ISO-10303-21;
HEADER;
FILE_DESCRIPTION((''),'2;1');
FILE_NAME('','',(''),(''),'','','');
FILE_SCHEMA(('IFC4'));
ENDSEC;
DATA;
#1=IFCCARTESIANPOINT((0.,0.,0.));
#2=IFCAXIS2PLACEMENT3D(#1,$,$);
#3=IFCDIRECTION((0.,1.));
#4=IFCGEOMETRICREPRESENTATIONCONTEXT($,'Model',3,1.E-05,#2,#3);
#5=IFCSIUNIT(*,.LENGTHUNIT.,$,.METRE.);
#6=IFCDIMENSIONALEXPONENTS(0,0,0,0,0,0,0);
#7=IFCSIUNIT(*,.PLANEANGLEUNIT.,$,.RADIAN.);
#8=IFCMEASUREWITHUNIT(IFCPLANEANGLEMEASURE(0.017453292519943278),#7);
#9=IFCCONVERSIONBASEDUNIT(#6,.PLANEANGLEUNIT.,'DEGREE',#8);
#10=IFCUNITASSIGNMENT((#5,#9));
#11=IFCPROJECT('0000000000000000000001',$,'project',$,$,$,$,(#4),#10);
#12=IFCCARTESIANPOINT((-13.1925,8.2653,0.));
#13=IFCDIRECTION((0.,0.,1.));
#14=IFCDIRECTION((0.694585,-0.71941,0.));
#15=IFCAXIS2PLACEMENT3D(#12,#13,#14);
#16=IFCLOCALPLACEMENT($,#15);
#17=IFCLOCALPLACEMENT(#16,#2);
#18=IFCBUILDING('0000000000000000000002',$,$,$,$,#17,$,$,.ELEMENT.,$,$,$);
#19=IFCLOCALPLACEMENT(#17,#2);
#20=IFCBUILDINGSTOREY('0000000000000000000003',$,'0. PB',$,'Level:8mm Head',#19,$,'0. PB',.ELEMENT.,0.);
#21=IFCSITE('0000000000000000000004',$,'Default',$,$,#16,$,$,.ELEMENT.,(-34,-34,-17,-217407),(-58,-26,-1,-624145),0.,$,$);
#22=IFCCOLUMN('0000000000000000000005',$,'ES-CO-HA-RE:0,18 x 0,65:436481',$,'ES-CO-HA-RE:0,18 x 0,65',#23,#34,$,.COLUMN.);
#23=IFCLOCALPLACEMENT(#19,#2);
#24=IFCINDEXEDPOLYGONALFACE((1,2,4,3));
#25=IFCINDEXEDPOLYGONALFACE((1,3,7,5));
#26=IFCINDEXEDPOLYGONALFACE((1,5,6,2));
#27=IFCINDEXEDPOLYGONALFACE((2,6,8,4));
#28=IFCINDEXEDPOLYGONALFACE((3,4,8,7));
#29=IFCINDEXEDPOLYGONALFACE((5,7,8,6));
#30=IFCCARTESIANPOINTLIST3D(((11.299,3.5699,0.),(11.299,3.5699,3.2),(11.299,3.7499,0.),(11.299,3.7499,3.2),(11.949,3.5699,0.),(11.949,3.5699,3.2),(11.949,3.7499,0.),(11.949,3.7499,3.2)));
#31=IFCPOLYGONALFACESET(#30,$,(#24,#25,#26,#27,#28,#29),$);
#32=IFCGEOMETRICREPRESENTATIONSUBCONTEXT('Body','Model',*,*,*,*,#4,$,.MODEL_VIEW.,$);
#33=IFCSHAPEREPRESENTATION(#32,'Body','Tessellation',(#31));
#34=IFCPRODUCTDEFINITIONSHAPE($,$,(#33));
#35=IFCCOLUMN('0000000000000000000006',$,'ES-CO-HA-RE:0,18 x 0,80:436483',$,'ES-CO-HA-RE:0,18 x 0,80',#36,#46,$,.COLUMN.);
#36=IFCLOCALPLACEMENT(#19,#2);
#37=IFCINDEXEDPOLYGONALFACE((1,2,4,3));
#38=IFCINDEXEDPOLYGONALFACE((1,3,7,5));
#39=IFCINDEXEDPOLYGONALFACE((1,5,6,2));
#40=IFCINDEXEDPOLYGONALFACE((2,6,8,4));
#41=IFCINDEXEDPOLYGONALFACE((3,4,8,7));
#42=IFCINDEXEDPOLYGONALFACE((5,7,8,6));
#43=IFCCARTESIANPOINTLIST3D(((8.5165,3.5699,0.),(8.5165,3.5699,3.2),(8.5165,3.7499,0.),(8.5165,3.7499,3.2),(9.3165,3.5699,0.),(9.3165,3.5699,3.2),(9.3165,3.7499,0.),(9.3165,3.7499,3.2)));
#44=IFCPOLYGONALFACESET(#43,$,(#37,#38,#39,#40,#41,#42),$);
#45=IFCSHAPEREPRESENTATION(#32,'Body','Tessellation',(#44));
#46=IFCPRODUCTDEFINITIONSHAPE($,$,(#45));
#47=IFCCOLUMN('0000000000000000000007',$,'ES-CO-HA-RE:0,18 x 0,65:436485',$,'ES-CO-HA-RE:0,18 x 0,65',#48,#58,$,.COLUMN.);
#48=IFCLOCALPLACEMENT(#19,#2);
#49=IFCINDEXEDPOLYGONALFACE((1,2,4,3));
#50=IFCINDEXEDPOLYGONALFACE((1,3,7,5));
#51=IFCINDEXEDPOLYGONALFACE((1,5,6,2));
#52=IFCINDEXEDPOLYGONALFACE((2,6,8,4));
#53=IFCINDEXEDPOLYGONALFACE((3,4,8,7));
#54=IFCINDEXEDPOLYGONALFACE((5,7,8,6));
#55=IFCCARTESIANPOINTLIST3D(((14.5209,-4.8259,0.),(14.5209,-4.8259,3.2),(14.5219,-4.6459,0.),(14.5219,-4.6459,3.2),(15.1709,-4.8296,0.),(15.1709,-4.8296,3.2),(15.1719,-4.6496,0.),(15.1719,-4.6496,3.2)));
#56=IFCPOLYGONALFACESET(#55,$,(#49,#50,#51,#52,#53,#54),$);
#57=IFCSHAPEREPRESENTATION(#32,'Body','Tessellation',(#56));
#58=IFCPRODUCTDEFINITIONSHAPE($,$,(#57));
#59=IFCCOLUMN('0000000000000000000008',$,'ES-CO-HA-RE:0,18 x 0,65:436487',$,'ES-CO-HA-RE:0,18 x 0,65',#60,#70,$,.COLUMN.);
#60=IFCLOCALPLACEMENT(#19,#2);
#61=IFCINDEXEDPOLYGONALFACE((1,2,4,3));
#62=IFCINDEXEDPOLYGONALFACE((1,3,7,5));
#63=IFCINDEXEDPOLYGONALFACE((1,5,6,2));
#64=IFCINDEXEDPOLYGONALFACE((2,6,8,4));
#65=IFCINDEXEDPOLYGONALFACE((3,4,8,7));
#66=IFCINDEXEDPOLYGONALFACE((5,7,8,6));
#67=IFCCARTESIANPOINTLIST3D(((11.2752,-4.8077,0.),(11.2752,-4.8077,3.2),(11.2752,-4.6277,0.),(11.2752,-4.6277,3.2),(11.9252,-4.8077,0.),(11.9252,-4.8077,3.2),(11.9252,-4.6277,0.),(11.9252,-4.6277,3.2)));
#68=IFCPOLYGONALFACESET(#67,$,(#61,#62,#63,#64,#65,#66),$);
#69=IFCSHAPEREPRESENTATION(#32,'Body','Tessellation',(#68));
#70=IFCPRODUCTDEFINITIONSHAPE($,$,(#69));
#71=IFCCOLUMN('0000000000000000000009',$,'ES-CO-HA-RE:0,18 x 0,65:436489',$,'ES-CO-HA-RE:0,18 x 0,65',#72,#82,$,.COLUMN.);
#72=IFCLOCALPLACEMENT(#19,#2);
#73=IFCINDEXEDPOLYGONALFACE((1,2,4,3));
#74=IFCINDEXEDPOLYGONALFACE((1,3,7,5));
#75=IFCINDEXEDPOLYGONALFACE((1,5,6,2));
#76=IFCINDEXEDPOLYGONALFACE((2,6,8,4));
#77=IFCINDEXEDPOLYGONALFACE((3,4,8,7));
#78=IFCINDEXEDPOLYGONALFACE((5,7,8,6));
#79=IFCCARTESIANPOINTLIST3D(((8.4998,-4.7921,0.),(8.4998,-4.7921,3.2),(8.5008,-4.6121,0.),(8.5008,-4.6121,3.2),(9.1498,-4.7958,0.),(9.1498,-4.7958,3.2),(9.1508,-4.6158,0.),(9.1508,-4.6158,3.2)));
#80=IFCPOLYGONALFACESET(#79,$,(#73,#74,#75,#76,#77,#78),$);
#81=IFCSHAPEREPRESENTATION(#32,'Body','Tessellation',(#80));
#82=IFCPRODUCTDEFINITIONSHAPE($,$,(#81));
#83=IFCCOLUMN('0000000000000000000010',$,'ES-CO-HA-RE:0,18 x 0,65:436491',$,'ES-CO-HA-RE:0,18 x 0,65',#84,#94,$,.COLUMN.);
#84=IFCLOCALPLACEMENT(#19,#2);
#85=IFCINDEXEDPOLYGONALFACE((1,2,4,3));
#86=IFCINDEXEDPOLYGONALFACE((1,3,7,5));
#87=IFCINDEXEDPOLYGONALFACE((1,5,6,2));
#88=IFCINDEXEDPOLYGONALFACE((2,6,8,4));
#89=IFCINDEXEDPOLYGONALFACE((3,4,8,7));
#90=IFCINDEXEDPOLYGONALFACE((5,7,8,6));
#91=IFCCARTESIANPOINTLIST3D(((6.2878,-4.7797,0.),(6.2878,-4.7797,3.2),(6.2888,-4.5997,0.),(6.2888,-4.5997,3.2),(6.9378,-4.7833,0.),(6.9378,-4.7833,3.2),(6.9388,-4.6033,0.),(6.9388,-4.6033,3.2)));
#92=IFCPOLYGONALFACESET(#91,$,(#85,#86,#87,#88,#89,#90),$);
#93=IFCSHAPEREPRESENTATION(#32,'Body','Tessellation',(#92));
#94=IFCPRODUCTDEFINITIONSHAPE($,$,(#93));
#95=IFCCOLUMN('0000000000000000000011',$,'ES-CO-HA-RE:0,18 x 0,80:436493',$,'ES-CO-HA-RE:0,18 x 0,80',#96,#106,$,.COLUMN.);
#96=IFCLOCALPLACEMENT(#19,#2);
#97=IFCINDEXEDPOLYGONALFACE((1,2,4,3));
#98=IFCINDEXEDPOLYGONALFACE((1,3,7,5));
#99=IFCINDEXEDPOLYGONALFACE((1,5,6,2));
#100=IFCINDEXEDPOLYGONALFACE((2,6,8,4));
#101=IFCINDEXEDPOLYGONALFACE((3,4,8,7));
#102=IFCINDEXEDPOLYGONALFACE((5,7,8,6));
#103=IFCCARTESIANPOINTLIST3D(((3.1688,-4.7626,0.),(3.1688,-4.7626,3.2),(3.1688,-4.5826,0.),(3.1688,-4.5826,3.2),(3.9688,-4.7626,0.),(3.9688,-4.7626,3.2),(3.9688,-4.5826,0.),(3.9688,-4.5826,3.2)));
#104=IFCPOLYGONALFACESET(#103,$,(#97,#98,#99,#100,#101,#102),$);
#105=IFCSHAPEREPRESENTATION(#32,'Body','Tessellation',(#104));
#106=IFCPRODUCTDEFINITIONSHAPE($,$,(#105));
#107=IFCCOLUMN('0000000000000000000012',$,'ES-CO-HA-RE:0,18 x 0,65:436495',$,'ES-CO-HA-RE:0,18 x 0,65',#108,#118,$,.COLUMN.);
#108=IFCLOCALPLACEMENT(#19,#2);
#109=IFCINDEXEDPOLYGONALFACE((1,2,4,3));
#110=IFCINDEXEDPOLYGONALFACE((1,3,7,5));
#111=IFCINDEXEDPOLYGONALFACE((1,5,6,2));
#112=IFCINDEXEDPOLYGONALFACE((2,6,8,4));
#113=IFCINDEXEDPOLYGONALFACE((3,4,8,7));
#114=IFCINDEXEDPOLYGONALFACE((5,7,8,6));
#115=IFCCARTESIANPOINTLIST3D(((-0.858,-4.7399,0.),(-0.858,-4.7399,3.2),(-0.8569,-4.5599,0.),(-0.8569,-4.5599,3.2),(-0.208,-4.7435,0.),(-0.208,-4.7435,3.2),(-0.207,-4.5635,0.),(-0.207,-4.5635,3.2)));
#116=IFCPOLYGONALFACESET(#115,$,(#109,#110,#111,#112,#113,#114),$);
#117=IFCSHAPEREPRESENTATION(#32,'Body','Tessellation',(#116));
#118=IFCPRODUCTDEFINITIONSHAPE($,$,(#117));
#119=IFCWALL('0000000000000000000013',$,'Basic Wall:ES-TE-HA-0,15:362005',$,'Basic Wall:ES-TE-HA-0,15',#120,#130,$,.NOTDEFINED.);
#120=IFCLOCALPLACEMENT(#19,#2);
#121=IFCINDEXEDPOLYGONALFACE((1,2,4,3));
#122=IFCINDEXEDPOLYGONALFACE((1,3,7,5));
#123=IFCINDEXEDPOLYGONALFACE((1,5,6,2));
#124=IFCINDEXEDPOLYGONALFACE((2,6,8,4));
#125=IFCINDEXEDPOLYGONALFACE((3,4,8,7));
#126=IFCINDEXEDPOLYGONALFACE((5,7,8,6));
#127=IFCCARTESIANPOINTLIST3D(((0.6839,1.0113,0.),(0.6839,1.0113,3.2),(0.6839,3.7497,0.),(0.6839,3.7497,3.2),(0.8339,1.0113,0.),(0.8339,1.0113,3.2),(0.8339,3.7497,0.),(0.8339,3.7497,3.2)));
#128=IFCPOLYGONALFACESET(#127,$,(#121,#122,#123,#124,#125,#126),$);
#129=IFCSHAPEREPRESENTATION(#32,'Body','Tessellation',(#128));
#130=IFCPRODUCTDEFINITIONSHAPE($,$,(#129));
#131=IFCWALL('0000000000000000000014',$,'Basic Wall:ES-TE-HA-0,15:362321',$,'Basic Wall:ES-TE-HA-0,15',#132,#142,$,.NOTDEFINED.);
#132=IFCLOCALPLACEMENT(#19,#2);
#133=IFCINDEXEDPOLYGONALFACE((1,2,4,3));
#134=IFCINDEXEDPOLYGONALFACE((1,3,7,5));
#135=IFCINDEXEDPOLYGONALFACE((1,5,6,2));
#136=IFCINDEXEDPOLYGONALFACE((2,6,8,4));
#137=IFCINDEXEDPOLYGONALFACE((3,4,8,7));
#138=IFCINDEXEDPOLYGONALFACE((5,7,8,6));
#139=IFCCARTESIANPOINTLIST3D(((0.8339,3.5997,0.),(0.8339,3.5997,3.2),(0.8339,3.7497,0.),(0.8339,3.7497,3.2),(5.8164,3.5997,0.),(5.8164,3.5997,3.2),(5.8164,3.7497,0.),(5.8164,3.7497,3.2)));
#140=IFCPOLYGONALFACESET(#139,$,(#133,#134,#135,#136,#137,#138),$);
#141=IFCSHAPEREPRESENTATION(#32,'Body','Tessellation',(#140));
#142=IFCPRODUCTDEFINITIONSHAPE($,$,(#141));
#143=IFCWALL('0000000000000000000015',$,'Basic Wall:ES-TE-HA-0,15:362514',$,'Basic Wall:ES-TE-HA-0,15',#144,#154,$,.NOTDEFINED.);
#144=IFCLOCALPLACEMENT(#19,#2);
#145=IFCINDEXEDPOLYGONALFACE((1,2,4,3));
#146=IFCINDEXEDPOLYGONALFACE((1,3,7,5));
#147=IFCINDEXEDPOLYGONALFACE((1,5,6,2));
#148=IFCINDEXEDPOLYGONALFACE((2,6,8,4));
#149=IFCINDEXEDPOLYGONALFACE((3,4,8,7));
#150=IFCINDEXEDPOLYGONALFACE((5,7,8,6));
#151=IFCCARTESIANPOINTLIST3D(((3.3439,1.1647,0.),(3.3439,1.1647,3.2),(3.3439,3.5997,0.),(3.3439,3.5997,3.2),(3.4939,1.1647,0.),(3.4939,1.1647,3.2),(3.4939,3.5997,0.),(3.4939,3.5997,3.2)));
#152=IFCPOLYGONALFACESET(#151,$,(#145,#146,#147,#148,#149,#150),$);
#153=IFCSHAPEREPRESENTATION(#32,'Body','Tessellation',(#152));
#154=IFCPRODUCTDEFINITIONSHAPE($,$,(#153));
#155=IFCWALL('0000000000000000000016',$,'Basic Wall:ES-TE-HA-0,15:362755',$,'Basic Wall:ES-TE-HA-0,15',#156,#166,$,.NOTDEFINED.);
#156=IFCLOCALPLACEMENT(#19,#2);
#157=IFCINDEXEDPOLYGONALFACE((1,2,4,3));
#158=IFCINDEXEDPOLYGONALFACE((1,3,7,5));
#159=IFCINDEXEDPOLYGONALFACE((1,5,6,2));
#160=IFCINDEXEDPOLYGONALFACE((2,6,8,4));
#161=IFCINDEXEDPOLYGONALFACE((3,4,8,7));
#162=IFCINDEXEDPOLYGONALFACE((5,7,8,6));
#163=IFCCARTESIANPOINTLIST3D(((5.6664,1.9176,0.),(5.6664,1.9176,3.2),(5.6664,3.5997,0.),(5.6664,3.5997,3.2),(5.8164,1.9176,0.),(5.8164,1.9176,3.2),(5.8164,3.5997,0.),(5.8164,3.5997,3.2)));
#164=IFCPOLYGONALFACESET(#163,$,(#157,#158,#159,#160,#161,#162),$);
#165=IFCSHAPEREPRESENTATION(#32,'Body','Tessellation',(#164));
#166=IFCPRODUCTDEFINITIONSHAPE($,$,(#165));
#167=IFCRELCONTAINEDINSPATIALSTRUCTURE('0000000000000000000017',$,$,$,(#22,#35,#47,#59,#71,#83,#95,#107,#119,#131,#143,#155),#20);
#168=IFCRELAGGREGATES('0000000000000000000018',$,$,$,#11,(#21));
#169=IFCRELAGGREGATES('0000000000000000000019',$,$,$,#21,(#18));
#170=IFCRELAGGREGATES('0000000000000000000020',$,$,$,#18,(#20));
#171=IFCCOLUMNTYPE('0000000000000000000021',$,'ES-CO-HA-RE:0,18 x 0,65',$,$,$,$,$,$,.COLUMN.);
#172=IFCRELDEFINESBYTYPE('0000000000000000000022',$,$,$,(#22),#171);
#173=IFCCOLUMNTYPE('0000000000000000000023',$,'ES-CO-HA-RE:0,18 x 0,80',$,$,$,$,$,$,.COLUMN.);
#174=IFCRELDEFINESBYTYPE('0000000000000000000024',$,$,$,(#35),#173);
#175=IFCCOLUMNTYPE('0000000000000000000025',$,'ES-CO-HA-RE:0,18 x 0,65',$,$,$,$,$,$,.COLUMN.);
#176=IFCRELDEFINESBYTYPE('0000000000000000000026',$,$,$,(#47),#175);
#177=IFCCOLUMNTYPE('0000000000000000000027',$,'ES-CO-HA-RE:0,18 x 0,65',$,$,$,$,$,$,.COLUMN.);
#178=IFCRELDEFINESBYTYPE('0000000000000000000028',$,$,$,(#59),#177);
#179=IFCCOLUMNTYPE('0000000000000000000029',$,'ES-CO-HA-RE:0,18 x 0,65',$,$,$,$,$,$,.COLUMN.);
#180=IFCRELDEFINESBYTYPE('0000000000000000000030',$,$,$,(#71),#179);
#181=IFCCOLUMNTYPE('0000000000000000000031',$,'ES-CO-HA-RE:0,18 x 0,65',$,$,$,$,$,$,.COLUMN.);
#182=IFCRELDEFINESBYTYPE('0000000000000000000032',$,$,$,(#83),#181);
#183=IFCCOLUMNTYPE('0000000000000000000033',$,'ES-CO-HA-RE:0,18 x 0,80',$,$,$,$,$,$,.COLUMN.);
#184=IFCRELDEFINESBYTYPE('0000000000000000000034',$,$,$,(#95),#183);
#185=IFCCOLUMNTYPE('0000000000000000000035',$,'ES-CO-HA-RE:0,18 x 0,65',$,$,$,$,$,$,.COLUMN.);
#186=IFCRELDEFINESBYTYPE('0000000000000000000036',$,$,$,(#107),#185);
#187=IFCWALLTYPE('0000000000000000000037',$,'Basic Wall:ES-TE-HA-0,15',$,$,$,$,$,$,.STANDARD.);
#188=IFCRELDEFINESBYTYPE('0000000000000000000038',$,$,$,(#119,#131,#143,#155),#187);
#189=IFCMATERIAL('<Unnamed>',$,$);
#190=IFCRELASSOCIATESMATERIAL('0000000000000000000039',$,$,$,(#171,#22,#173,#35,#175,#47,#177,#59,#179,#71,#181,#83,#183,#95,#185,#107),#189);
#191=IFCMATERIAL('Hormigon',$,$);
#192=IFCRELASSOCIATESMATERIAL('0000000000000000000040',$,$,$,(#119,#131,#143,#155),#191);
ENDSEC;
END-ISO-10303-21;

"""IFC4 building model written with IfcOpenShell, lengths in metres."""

from ifc_helpers import new_model, entity, si_unit, converted_unit, direction, frame, origin, place, context, subcontext, project, spatial, indexed_curve, outline, extrude, source, transform, mapped, material, type_object, type_shapes, element, save


model = new_model("IFC4")

# Units and contexts
model_context = context("Model", 3, precision=1e-05, world=origin(), true_north=direction((0.0, 1.0)))
body_context = subcontext(model_context, "Body", "Model", "MODEL_VIEW")
ifc_project = project(units=[si_unit("LENGTHUNIT", "METRE"), converted_unit("PLANEANGLEUNIT", "DEGREE", entity("IfcPlaneAngleMeasure", 0.017453292519943278), si_unit("PLANEANGLEUNIT", "RADIAN"), dimensions=[0, 0, 0, 0, 0, 0, 0])], contexts=[model_context])

# Site, building, storey
site_placement = place(None, frame((-13.1925, 8.2653, 0.0), z_axis=(0.0, 0.0, 1.0), x_axis=(0.694585, -0.71941, 0.0)))
site = spatial("IfcSite", under=ifc_project, at=site_placement, Name="Default", CompositionType="ELEMENT", RefLatitude=(-34, -34, -17, -217407), RefLongitude=(-58, -26, -1, -624145), RefElevation=0.0)
building_placement = place(site_placement, origin())
building = spatial("IfcBuilding", under=site, at=building_placement, CompositionType="ELEMENT")
storey_placement = place(building_placement, origin())
storey = spatial("IfcBuildingStorey", under=building, at=storey_placement, Name="0. PB", ObjectType="Level:8mm Head", LongName="0. PB", CompositionType="ELEMENT", Elevation=0.0)

# Columns
ifc_material_1 = material(Name="<Unnamed>")
ifc_material_2 = material(Name="Hormigon")
column_type_1 = type_object("IfcColumnType", Name="ES-CO-HA-RE:0,18 x 0,65", PredefinedType="COLUMN", material=ifc_material_1)
shared_shape_1 = source(origin(), body_context, "Body", "SweptSolid", [
    extrude(outline(indexed_curve([(-0.325, -0.09), (0.325, -0.09), (0.325, 0.09), (-0.325, 0.09), (-0.325, -0.09)], self_intersect=False)), frame((11.624, 3.6599, 0.0), z_axis=(0.0, 0.0, 1.0), x_axis=(-1.0, 0.0, 0.0)), (0.0, 0.0, 1.0), 3.2),
])
type_shapes(column_type_1, [shared_shape_1])
column_1_placement = place(storey_placement, origin())
element("IfcColumn", 1, at=column_1_placement, inside=storey, type_object=column_type_1, material=ifc_material_1, Name="ES-CO-HA-RE:0,18 x 0,65:436481", ObjectType="ES-CO-HA-RE:0,18 x 0,65", PredefinedType="COLUMN", context=body_context, shape_type="MappedRepresentation", body=[
    mapped(shared_shape_1, transform((0.0, 0.0, 0.0), scale=1.0)),
])
column_type_2 = type_object("IfcColumnType", Name="ES-CO-HA-RE:0,18 x 0,80", PredefinedType="COLUMN", material=ifc_material_1)
shared_shape_2 = source(origin(), body_context, "Body", "SweptSolid", [
    extrude(outline(indexed_curve([(-0.4, -0.09), (0.4, -0.09), (0.4, 0.09), (-0.4, 0.09), (-0.4, -0.09)], self_intersect=False)), frame((8.9165, 3.6599, 0.0), z_axis=(0.0, 0.0, 1.0), x_axis=(-1.0, 0.0, 0.0)), (0.0, 0.0, 1.0), 3.2),
])
type_shapes(column_type_2, [shared_shape_2])
column_2_placement = place(storey_placement, origin())
element("IfcColumn", 2, at=column_2_placement, inside=storey, type_object=column_type_2, material=ifc_material_1, Name="ES-CO-HA-RE:0,18 x 0,80:436483", ObjectType="ES-CO-HA-RE:0,18 x 0,80", PredefinedType="COLUMN", context=body_context, shape_type="MappedRepresentation", body=[
    mapped(shared_shape_2, transform((0.0, 0.0, 0.0), scale=1.0)),
])
column_type_3 = type_object("IfcColumnType", Name="ES-CO-HA-RE:0,18 x 0,65", PredefinedType="COLUMN", material=ifc_material_1)
shared_shape_3 = source(origin(), body_context, "Body", "SweptSolid", [
    extrude(outline(indexed_curve([(-0.325, -0.09), (0.325, -0.09), (0.325, 0.09), (-0.325, 0.09), (-0.325, -0.09)], self_intersect=False)), frame((14.8464, -4.7378, 0.0), z_axis=(0.0, 0.0, 1.0), x_axis=(-0.999984, 0.005619, 0.0)), (0.0, 0.0, 1.0), 3.2),
])
type_shapes(column_type_3, [shared_shape_3])
column_3_placement = place(storey_placement, origin())
element("IfcColumn", 3, at=column_3_placement, inside=storey, type_object=column_type_3, material=ifc_material_1, Name="ES-CO-HA-RE:0,18 x 0,65:436485", ObjectType="ES-CO-HA-RE:0,18 x 0,65", PredefinedType="COLUMN", context=body_context, shape_type="MappedRepresentation", body=[
    mapped(shared_shape_3, transform((0.0, 0.0, 0.0), scale=1.0)),
])
column_type_4 = type_object("IfcColumnType", Name="ES-CO-HA-RE:0,18 x 0,65", PredefinedType="COLUMN", material=ifc_material_1)
shared_shape_4 = source(origin(), body_context, "Body", "SweptSolid", [
    extrude(outline(indexed_curve([(-0.325, -0.09), (0.325, -0.09), (0.325, 0.09), (-0.325, 0.09), (-0.325, -0.09)], self_intersect=False)), frame((11.6002, -4.7177, 0.0), z_axis=(0.0, 0.0, 1.0), x_axis=(-1.0, 0.0, 0.0)), (0.0, 0.0, 1.0), 3.2),
])
type_shapes(column_type_4, [shared_shape_4])
column_4_placement = place(storey_placement, origin())
element("IfcColumn", 4, at=column_4_placement, inside=storey, type_object=column_type_4, material=ifc_material_1, Name="ES-CO-HA-RE:0,18 x 0,65:436487", ObjectType="ES-CO-HA-RE:0,18 x 0,65", PredefinedType="COLUMN", context=body_context, shape_type="MappedRepresentation", body=[
    mapped(shared_shape_4, transform((0.0, 0.0, 0.0), scale=1.0)),
])
column_type_5 = type_object("IfcColumnType", Name="ES-CO-HA-RE:0,18 x 0,65", PredefinedType="COLUMN", material=ifc_material_1)
shared_shape_5 = source(origin(), body_context, "Body", "SweptSolid", [
    extrude(outline(indexed_curve([(-0.325, -0.09), (0.325, -0.09), (0.325, 0.09), (-0.325, 0.09), (-0.325, -0.09)], self_intersect=False)), frame((8.8253, -4.7039, 0.0), z_axis=(0.0, 0.0, 1.0), x_axis=(-0.999984, 0.005619, 0.0)), (0.0, 0.0, 1.0), 3.2),
])
type_shapes(column_type_5, [shared_shape_5])
column_5_placement = place(storey_placement, origin())
element("IfcColumn", 5, at=column_5_placement, inside=storey, type_object=column_type_5, material=ifc_material_1, Name="ES-CO-HA-RE:0,18 x 0,65:436489", ObjectType="ES-CO-HA-RE:0,18 x 0,65", PredefinedType="COLUMN", context=body_context, shape_type="MappedRepresentation", body=[
    mapped(shared_shape_5, transform((0.0, 0.0, 0.0), scale=1.0)),
])
column_type_6 = type_object("IfcColumnType", Name="ES-CO-HA-RE:0,18 x 0,65", PredefinedType="COLUMN", material=ifc_material_1)
shared_shape_6 = source(origin(), body_context, "Body", "SweptSolid", [
    extrude(outline(indexed_curve([(-0.325, -0.09), (0.325, -0.09), (0.325, 0.09), (-0.325, 0.09), (-0.325, -0.09)], self_intersect=False)), frame((6.6133, -4.6915, 0.0), z_axis=(0.0, 0.0, 1.0), x_axis=(-0.999984, 0.005624, 0.0)), (0.0, 0.0, 1.0), 3.2),
])
type_shapes(column_type_6, [shared_shape_6])
column_6_placement = place(storey_placement, origin())
element("IfcColumn", 6, at=column_6_placement, inside=storey, type_object=column_type_6, material=ifc_material_1, Name="ES-CO-HA-RE:0,18 x 0,65:436491", ObjectType="ES-CO-HA-RE:0,18 x 0,65", PredefinedType="COLUMN", context=body_context, shape_type="MappedRepresentation", body=[
    mapped(shared_shape_6, transform((0.0, 0.0, 0.0), scale=1.0)),
])
column_type_7 = type_object("IfcColumnType", Name="ES-CO-HA-RE:0,18 x 0,80", PredefinedType="COLUMN", material=ifc_material_1)
shared_shape_7 = source(origin(), body_context, "Body", "SweptSolid", [
    extrude(outline(indexed_curve([(-0.4, -0.09), (0.4, -0.09), (0.4, 0.09), (-0.4, 0.09), (-0.4, -0.09)], self_intersect=False)), frame((3.5688, -4.6726, 0.0), z_axis=(0.0, 0.0, 1.0), x_axis=(-1.0, 0.0, 0.0)), (0.0, 0.0, 1.0), 3.2),
])
type_shapes(column_type_7, [shared_shape_7])
column_7_placement = place(storey_placement, origin())
element("IfcColumn", 7, at=column_7_placement, inside=storey, type_object=column_type_7, material=ifc_material_1, Name="ES-CO-HA-RE:0,18 x 0,80:436493", ObjectType="ES-CO-HA-RE:0,18 x 0,80", PredefinedType="COLUMN", context=body_context, shape_type="MappedRepresentation", body=[
    mapped(shared_shape_7, transform((0.0, 0.0, 0.0), scale=1.0)),
])
column_type_8 = type_object("IfcColumnType", Name="ES-CO-HA-RE:0,18 x 0,65", PredefinedType="COLUMN", material=ifc_material_1)
shared_shape_8 = source(origin(), body_context, "Body", "SweptSolid", [
    extrude(outline(indexed_curve([(-0.325, -0.09), (0.325, -0.09), (0.325, 0.09), (-0.325, 0.09), (-0.325, -0.09)], self_intersect=False)), frame((-0.5325, -4.6517, 0.0), z_axis=(0.0, 0.0, 1.0), x_axis=(-0.999984, 0.005624, 0.0)), (0.0, 0.0, 1.0), 3.2),
])
type_shapes(column_type_8, [shared_shape_8])
column_8_placement = place(storey_placement, origin())
element("IfcColumn", 8, at=column_8_placement, inside=storey, type_object=column_type_8, material=ifc_material_1, Name="ES-CO-HA-RE:0,18 x 0,65:436495", ObjectType="ES-CO-HA-RE:0,18 x 0,65", PredefinedType="COLUMN", context=body_context, shape_type="MappedRepresentation", body=[
    mapped(shared_shape_8, transform((0.0, 0.0, 0.0), scale=1.0)),
])

# Walls
wall_type = type_object("IfcWallType", Name="Basic Wall:ES-TE-HA-0,15", PredefinedType="STANDARD")
wall_1_placement = place(storey_placement, frame((0.7589, 1.0113, 0.0), z_axis=(0.0, 0.0, 1.0), x_axis=(0.0, 1.0, 0.0)))
element("IfcWall", 9, at=wall_1_placement, inside=storey, type_object=wall_type, material=ifc_material_2, Name="Basic Wall:ES-TE-HA-0,15:362005", ObjectType="Basic Wall:ES-TE-HA-0,15", PredefinedType="NOTDEFINED", context=body_context, shape_type="SweptSolid", body=[
    extrude(outline(indexed_curve([(2.7384, 0.075), (0.0, 0.075), (0.0, -0.075), (2.7384, -0.075), (2.7384, 0.075)], self_intersect=False)), origin(), (0.0, 0.0, 1.0), 3.2),
])
wall_2_placement = place(storey_placement, frame((0.8339, 3.6747, 0.0)))
element("IfcWall", 10, at=wall_2_placement, inside=storey, type_object=wall_type, material=ifc_material_2, Name="Basic Wall:ES-TE-HA-0,15:362321", ObjectType="Basic Wall:ES-TE-HA-0,15", PredefinedType="NOTDEFINED", context=body_context, shape_type="SweptSolid", body=[
    extrude(outline(indexed_curve([(4.9825, 0.075), (0.0, 0.075), (0.0, -0.075), (4.9825, -0.075), (4.9825, 0.075)], self_intersect=False)), origin(), (0.0, 0.0, 1.0), 3.2),
])
wall_3_placement = place(storey_placement, frame((3.4189, 3.5997, 0.0), z_axis=(0.0, 0.0, 1.0), x_axis=(0.0, -1.0, 0.0)))
element("IfcWall", 11, at=wall_3_placement, inside=storey, type_object=wall_type, material=ifc_material_2, Name="Basic Wall:ES-TE-HA-0,15:362514", ObjectType="Basic Wall:ES-TE-HA-0,15", PredefinedType="NOTDEFINED", context=body_context, shape_type="SweptSolid", body=[
    extrude(outline(indexed_curve([(2.435, 0.075), (0.0, 0.075), (0.0, -0.075), (2.435, -0.075), (2.435, 0.075)], self_intersect=False)), origin(), (0.0, 0.0, 1.0), 3.2),
])
wall_4_placement = place(storey_placement, frame((5.7414, 1.9176, 0.0), z_axis=(0.0, 0.0, 1.0), x_axis=(0.0, 1.0, 0.0)))
element("IfcWall", 12, at=wall_4_placement, inside=storey, type_object=wall_type, material=ifc_material_2, Name="Basic Wall:ES-TE-HA-0,15:362755", ObjectType="Basic Wall:ES-TE-HA-0,15", PredefinedType="NOTDEFINED", context=body_context, shape_type="SweptSolid", body=[
    extrude(outline(indexed_curve([(1.682, 0.075), (0.0, 0.075), (0.0, -0.075), (1.682, -0.075), (1.682, 0.075)], self_intersect=False)), origin(), (0.0, 0.0, 1.0), 3.2),
])

save(model, "model.ifc")
